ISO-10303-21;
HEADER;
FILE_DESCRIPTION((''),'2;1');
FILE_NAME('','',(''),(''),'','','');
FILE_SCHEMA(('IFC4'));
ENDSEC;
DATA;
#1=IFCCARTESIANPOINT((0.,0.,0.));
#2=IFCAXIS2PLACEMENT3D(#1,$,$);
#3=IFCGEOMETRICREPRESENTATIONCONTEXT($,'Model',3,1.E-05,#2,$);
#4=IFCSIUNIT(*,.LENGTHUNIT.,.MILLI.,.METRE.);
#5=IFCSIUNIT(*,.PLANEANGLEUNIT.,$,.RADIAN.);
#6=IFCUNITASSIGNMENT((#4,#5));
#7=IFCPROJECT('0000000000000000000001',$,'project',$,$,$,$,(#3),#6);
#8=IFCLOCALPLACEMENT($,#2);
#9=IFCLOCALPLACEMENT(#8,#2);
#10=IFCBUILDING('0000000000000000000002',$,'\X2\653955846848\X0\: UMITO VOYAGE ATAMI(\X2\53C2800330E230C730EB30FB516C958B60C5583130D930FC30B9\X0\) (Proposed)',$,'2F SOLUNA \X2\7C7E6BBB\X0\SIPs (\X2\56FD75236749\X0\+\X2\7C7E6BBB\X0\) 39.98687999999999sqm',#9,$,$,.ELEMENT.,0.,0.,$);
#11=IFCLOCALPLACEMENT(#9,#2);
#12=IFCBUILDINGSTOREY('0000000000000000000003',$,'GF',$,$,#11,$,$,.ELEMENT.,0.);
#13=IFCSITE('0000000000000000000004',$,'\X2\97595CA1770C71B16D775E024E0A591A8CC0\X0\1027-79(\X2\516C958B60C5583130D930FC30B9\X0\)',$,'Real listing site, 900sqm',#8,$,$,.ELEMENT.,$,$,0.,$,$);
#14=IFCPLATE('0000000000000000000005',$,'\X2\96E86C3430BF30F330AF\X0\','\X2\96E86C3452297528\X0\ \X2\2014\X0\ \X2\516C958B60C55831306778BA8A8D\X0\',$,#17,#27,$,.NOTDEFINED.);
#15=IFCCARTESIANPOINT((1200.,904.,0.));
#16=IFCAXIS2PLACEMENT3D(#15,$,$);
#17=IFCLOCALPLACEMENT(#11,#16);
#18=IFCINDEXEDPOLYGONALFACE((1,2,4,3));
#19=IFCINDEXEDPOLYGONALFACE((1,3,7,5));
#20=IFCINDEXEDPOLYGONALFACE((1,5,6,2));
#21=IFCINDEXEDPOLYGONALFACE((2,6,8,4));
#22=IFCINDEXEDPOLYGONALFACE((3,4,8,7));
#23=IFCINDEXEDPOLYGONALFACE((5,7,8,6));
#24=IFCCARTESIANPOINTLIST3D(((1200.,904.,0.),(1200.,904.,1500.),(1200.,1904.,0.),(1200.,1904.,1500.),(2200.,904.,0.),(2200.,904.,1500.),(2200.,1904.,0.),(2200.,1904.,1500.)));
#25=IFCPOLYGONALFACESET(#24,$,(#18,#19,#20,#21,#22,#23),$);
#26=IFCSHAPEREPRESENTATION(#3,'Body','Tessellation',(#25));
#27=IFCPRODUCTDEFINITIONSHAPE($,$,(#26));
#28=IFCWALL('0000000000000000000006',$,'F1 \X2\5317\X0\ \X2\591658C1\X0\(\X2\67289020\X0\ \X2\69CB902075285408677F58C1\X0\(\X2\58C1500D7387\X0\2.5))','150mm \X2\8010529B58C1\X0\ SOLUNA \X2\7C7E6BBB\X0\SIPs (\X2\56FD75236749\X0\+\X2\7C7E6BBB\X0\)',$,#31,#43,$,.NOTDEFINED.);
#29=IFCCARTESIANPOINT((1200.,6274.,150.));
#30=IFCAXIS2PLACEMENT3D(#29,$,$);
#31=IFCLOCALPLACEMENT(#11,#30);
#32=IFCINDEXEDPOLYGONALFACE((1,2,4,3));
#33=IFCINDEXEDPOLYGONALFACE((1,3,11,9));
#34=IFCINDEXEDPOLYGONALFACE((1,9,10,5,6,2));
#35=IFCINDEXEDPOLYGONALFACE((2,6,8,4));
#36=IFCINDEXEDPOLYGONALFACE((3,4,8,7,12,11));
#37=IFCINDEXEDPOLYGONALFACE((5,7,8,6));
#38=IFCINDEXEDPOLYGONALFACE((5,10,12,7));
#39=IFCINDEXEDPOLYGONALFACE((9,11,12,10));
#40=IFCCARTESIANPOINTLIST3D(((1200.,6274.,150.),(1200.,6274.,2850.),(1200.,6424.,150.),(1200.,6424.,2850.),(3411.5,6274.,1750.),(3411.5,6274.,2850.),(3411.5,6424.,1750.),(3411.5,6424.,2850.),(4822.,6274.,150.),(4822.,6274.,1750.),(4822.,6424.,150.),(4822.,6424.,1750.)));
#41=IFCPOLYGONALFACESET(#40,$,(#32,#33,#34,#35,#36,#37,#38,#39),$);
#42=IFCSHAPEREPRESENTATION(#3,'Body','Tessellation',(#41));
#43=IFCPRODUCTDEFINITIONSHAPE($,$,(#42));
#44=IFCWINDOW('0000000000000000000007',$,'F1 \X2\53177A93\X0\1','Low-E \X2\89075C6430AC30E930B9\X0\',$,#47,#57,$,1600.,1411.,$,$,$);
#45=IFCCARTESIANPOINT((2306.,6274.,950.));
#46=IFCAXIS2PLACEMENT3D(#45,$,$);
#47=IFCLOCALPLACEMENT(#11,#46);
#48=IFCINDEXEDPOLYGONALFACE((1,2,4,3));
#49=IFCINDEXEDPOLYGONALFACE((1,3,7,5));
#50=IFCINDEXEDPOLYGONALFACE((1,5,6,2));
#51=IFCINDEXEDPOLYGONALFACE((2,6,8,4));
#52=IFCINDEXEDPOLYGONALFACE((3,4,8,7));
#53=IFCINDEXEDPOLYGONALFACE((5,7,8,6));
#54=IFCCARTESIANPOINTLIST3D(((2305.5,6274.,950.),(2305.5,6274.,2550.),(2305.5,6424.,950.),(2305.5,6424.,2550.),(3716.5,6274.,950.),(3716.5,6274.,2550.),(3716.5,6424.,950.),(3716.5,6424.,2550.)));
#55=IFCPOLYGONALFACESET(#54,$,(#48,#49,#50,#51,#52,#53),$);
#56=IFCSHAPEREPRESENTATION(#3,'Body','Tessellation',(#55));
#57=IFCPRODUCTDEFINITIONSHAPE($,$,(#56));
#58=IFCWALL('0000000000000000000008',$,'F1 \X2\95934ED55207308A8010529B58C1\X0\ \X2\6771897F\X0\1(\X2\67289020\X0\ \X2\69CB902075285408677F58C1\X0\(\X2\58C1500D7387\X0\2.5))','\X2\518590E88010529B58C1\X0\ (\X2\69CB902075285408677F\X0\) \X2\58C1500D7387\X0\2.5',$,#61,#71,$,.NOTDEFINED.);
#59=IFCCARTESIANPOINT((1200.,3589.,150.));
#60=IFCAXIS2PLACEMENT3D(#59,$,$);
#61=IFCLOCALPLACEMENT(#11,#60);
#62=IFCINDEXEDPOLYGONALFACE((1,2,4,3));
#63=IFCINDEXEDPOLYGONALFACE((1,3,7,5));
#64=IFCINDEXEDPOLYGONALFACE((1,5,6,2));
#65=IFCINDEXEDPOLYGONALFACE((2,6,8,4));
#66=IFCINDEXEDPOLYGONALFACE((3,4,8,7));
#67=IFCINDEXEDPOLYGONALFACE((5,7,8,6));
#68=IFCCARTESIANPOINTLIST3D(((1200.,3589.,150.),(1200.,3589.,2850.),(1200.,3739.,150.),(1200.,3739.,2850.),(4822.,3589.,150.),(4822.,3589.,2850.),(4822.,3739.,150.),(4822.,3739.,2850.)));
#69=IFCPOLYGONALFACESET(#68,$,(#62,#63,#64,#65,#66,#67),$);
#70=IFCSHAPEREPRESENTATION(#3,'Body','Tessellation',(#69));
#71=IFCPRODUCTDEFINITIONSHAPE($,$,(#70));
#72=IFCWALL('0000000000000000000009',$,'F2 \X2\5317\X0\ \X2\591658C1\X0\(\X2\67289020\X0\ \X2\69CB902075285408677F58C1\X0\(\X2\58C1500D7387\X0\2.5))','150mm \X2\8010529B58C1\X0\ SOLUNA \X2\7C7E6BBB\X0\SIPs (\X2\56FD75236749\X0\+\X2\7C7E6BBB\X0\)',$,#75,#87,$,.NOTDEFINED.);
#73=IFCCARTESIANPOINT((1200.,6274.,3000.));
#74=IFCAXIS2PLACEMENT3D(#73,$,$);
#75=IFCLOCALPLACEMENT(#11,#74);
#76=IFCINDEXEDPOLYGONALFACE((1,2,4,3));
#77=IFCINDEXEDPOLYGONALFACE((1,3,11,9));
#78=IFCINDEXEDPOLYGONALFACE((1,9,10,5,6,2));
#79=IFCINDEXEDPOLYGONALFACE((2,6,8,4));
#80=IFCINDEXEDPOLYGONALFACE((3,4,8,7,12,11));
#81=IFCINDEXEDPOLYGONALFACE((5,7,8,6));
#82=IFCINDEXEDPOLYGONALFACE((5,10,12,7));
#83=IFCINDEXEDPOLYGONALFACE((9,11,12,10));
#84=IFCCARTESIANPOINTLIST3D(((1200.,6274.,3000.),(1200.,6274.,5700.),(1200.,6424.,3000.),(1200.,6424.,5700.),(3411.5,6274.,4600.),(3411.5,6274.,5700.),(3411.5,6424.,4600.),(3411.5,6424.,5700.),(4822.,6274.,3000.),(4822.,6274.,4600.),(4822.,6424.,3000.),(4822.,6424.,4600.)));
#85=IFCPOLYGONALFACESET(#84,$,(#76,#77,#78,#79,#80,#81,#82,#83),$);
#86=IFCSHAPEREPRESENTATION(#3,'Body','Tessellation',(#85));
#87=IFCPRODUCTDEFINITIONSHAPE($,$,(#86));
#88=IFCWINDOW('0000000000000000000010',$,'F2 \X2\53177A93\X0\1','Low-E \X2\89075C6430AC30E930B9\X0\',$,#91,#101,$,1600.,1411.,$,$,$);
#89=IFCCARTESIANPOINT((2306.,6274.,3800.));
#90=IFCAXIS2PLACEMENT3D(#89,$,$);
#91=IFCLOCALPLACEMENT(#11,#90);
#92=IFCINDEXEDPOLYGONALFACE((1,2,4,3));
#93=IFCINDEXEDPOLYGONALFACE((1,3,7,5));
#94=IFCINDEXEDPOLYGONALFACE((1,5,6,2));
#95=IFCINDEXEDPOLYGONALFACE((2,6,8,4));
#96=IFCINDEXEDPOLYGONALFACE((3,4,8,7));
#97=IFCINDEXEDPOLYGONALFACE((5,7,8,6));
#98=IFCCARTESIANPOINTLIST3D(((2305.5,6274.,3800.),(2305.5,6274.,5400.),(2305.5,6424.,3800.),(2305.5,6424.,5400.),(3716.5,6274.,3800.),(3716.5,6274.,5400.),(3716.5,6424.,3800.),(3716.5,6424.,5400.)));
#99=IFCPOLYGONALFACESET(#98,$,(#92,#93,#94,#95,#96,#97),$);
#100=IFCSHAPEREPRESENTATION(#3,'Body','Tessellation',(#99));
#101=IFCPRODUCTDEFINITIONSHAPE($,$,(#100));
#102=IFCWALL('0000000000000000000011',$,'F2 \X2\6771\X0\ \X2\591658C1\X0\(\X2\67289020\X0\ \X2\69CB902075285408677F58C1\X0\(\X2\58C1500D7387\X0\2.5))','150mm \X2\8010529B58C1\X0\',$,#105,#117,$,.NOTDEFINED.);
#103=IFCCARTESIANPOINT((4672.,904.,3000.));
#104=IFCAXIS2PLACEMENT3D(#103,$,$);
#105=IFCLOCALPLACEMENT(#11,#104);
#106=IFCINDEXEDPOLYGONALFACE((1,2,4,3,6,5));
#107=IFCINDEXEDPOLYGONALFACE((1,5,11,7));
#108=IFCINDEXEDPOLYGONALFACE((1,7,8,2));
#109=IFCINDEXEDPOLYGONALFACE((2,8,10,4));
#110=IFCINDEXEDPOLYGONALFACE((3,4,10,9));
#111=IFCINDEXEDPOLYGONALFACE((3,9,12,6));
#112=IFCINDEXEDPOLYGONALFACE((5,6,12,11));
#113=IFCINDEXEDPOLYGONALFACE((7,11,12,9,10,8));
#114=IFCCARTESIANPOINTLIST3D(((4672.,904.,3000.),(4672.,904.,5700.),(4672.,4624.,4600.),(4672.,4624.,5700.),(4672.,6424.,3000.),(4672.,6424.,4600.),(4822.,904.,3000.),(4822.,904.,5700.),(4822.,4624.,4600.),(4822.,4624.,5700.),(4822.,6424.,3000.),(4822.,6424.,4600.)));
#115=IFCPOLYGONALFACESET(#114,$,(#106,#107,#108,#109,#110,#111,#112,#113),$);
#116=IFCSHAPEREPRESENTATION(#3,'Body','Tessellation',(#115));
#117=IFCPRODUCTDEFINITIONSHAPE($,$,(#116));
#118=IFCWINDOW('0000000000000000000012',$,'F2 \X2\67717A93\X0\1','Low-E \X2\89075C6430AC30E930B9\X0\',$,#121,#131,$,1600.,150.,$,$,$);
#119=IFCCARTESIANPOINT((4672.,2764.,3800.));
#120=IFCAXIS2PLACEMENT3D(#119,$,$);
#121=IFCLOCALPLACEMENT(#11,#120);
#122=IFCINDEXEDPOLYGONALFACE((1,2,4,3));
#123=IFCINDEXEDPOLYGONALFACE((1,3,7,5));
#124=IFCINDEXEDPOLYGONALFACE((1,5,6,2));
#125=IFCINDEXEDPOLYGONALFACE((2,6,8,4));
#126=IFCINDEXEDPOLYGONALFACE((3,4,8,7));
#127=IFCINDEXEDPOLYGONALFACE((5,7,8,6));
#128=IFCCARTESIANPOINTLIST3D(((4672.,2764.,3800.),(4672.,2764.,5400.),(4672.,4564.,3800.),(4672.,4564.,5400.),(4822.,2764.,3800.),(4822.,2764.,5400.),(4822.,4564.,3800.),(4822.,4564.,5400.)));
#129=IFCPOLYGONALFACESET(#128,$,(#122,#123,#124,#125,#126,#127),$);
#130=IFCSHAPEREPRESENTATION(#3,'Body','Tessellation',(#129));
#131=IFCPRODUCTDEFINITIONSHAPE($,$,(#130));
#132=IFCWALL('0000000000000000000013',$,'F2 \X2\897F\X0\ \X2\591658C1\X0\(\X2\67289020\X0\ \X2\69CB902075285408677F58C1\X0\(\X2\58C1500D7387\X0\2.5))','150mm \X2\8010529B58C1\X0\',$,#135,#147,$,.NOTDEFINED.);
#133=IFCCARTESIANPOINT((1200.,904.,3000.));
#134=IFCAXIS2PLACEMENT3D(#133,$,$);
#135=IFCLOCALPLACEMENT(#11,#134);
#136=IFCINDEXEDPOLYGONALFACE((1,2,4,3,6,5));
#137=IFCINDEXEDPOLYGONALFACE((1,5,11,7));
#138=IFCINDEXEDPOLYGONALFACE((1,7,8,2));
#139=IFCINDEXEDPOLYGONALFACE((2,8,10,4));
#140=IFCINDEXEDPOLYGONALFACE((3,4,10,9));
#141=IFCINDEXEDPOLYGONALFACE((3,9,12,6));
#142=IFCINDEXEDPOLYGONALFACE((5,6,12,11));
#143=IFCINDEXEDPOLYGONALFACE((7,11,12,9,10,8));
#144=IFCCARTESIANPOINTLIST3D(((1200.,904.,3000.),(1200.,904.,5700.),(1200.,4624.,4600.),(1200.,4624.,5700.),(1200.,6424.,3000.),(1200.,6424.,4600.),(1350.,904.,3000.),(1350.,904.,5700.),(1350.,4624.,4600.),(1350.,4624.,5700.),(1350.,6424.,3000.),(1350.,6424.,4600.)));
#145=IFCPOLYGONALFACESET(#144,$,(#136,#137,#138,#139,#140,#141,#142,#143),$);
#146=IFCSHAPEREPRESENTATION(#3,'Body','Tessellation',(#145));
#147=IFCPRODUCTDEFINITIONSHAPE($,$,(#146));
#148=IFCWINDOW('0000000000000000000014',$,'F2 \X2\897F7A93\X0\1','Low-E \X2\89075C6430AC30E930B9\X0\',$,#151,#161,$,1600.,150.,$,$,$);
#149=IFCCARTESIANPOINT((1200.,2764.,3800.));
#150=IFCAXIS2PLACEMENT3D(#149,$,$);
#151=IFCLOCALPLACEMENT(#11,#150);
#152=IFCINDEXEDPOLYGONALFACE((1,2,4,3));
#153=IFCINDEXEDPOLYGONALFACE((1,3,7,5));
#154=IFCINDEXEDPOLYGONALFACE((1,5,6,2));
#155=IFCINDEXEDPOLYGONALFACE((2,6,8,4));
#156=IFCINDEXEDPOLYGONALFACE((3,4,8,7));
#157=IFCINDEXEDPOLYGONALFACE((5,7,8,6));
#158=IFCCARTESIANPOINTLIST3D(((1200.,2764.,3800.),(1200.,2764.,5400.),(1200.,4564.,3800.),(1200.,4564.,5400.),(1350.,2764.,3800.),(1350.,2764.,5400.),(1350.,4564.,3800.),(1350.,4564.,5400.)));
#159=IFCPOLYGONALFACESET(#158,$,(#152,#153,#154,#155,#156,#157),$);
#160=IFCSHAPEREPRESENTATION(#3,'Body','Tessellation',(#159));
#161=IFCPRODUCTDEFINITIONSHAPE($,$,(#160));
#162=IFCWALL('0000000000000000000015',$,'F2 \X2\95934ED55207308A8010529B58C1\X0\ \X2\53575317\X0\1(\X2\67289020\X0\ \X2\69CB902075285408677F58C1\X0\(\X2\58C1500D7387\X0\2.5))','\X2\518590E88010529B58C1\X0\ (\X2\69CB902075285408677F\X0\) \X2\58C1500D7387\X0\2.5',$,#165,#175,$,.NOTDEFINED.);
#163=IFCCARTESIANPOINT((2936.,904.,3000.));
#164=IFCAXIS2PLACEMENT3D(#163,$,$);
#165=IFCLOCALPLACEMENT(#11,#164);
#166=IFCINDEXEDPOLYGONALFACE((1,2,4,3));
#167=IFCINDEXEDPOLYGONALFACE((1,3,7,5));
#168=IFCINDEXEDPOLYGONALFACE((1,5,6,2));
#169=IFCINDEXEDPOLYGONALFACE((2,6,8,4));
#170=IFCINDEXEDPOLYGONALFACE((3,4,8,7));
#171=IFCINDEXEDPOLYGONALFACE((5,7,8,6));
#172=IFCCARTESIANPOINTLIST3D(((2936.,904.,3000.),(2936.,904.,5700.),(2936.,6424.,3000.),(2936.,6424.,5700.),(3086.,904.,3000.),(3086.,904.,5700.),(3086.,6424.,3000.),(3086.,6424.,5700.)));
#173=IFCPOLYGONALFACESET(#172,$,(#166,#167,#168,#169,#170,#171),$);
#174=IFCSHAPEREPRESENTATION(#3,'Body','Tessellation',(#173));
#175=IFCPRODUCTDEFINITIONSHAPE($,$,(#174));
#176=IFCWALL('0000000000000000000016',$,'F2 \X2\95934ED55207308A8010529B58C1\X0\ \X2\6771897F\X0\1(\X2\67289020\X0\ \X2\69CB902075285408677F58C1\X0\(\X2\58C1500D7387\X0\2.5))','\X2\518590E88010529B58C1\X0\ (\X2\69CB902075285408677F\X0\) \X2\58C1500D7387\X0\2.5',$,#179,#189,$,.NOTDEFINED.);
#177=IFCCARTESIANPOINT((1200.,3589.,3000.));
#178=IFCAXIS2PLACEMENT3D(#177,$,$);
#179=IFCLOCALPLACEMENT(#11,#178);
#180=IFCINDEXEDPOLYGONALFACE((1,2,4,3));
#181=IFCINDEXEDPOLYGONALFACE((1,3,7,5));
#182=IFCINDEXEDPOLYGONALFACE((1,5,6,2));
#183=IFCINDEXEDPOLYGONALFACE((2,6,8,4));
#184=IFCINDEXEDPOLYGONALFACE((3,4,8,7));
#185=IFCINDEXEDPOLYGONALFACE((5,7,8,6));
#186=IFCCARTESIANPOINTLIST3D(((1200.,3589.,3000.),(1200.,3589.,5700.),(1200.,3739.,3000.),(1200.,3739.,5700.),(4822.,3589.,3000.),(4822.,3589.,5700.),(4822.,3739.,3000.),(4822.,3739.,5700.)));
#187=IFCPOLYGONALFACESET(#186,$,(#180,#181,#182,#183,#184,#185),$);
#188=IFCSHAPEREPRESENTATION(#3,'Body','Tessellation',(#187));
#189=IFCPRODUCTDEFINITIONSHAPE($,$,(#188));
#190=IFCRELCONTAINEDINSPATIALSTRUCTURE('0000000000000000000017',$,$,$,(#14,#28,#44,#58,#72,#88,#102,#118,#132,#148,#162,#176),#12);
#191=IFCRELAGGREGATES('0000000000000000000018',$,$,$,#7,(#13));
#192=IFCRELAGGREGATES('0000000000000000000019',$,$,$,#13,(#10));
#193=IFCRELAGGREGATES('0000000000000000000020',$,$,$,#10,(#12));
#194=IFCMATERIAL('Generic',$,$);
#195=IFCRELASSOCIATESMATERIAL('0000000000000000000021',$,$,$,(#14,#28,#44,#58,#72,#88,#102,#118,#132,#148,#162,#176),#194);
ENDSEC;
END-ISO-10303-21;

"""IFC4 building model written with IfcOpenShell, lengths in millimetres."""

from ifc_helpers import new_model, si_unit, frame, frame_2d, origin, place, context, project, spatial, rectangle, extrude, material, element, fill, save


model = new_model("IFC4")

# Units and contexts
model_context = context("Model", 3, precision=1e-05, world=origin())
ifc_project = project(units=[si_unit("LENGTHUNIT", "METRE", prefix="MILLI"), si_unit("PLANEANGLEUNIT", "RADIAN")], contexts=[model_context])

# Site, building, storey
site_placement = place(None, origin())
site = spatial("IfcSite", under=ifc_project, at=site_placement, Name="静岡県熱海市上多賀1027-79(公開情報ベース)", ObjectType="Real listing site, 900sqm", CompositionType="ELEMENT", RefElevation=0.0)
building_placement = place(site_placement, origin())
building = spatial("IfcBuilding", under=site, at=building_placement, Name="改善案: UMITO VOYAGE ATAMI(参考モデル・公開情報ベース) (Proposed)", ObjectType="2F SOLUNA 籾殻SIPs (国産杉+籾殻) 39.98687999999999sqm", CompositionType="ELEMENT", ElevationOfRefHeight=0.0, ElevationOfTerrain=0.0)
storey_placement = place(building_placement, origin())
storey = spatial("IfcBuildingStorey", under=building, at=storey_placement, Name="GF", CompositionType="ELEMENT", Elevation=0.0)

# Plate
ifc_material_1 = material(Name="Generic")
plate_placement = place(storey_placement, frame((1200.0, 904.0, 0.0)))
element("IfcPlate", 1, at=plate_placement, inside=storey, material=ifc_material_1, Name="雨水タンク", Description="雨水利用 — 公開情報で確認", PredefinedType="NOTDEFINED", context=model_context, shape_type="SweptSolid", body=[
    extrude(rectangle(XDim=1000.0, YDim=1000.0, at=frame_2d((500.0, 500.0))), frame((1200.0, 904.0, 0.0)), (0.0, 0.0, 1.0), 1500.0),
])

# Wall, opening, window
wall_1_placement = place(storey_placement, frame((1200.0, 6274.0, 150.0)))
wall_1 = element("IfcWall", 2, at=wall_1_placement, inside=storey, material=ifc_material_1, Name="F1 北 外壁(木造 構造用合板壁(壁倍率2.5))", Description="150mm 耐力壁 SOLUNA 籾殻SIPs (国産杉+籾殻)", PredefinedType="NOTDEFINED", context=model_context, shape_type="SweptSolid", body=[
    extrude(rectangle(XDim=3622.0, YDim=150.0, at=frame_2d((1811.0, 75.0))), frame((1200.0, 6274.0, 150.0)), (0.0, 0.0, 1.0), 2700.0),
])
opening_1_placement = place(storey_placement, frame((2306.0, 6274.0, 950.0)))
opening_1 = element("IfcOpeningElement", 3, at=opening_1_placement, cuts=wall_1, PredefinedType="NOTDEFINED", context=model_context, shape_type="SweptSolid", body=[
    extrude(rectangle(XDim=1411.0, YDim=150.0, at=frame_2d((705.0, 75.0))), frame((2306.0, 6274.0, 950.0)), (0.0, 0.0, 1.0), 1600.0),
])
window_1_placement = place(storey_placement, frame((2306.0, 6274.0, 950.0)))
window_1 = element("IfcWindow", 4, at=window_1_placement, inside=storey, material=ifc_material_1, Name="F1 北窓1", Description="Low-E 複層ガラス", OverallHeight=1600.0, OverallWidth=1411.0, context=model_context, shape_type="SweptSolid", body=[
    extrude(rectangle(XDim=1411.0, YDim=150.0, at=frame_2d((705.0, 75.0))), frame((2306.0, 6274.0, 950.0)), (0.0, 0.0, 1.0), 1600.0),
])
fill(opening_1, window_1)

# Wall
wall_2_placement = place(storey_placement, frame((1200.0, 3589.0, 150.0)))
element("IfcWall", 5, at=wall_2_placement, inside=storey, material=ifc_material_1, Name="F1 間仕切り耐力壁 東西1(木造 構造用合板壁(壁倍率2.5))", Description="内部耐力壁 (構造用合板) 壁倍率2.5", PredefinedType="NOTDEFINED", context=model_context, shape_type="SweptSolid", body=[
    extrude(rectangle(XDim=3622.0, YDim=150.0, at=frame_2d((1811.0, 75.0))), frame((1200.0, 3589.0, 150.0)), (0.0, 0.0, 1.0), 2700.0),
])

# Walls, openings, windows
wall_3_placement = place(storey_placement, frame((1200.0, 6274.0, 3000.0)))
wall_3 = element("IfcWall", 6, at=wall_3_placement, inside=storey, material=ifc_material_1, Name="F2 北 外壁(木造 構造用合板壁(壁倍率2.5))", Description="150mm 耐力壁 SOLUNA 籾殻SIPs (国産杉+籾殻)", PredefinedType="NOTDEFINED", context=model_context, shape_type="SweptSolid", body=[
    extrude(rectangle(XDim=3622.0, YDim=150.0, at=frame_2d((1811.0, 75.0))), frame((1200.0, 6274.0, 3000.0)), (0.0, 0.0, 1.0), 2700.0),
])
opening_2_placement = place(storey_placement, frame((2306.0, 6274.0, 3800.0)))
opening_2 = element("IfcOpeningElement", 7, at=opening_2_placement, cuts=wall_3, PredefinedType="NOTDEFINED", context=model_context, shape_type="SweptSolid", body=[
    extrude(rectangle(XDim=1411.0, YDim=150.0, at=frame_2d((705.0, 75.0))), frame((2306.0, 6274.0, 3800.0)), (0.0, 0.0, 1.0), 1600.0),
])
window_2_placement = place(storey_placement, frame((2306.0, 6274.0, 3800.0)))
window_2 = element("IfcWindow", 8, at=window_2_placement, inside=storey, material=ifc_material_1, Name="F2 北窓1", Description="Low-E 複層ガラス", OverallHeight=1600.0, OverallWidth=1411.0, context=model_context, shape_type="SweptSolid", body=[
    extrude(rectangle(XDim=1411.0, YDim=150.0, at=frame_2d((705.0, 75.0))), frame((2306.0, 6274.0, 3800.0)), (0.0, 0.0, 1.0), 1600.0),
])
fill(opening_2, window_2)
wall_4_placement = place(storey_placement, frame((4672.0, 904.0, 3000.0)))
wall_4 = element("IfcWall", 9, at=wall_4_placement, inside=storey, material=ifc_material_1, Name="F2 東 外壁(木造 構造用合板壁(壁倍率2.5))", Description="150mm 耐力壁", PredefinedType="NOTDEFINED", context=model_context, shape_type="SweptSolid", body=[
    extrude(rectangle(XDim=150.0, YDim=5520.0, at=frame_2d((75.0, 2760.0))), frame((4672.0, 904.0, 3000.0)), (0.0, 0.0, 1.0), 2700.0),
])
opening_3_placement = place(storey_placement, frame((4672.0, 2764.0, 3800.0)))
opening_3 = element("IfcOpeningElement", 10, at=opening_3_placement, cuts=wall_4, PredefinedType="NOTDEFINED", context=model_context, shape_type="SweptSolid", body=[
    extrude(rectangle(XDim=150.0, YDim=1800.0, at=frame_2d((75.0, 900.0))), frame((4672.0, 2764.0, 3800.0)), (0.0, 0.0, 1.0), 1600.0),
])
window_3_placement = place(storey_placement, frame((4672.0, 2764.0, 3800.0)))
window_3 = element("IfcWindow", 11, at=window_3_placement, inside=storey, material=ifc_material_1, Name="F2 東窓1", Description="Low-E 複層ガラス", OverallHeight=1600.0, OverallWidth=150.0, context=model_context, shape_type="SweptSolid", body=[
    extrude(rectangle(XDim=150.0, YDim=1800.0, at=frame_2d((75.0, 900.0))), frame((4672.0, 2764.0, 3800.0)), (0.0, 0.0, 1.0), 1600.0),
])
fill(opening_3, window_3)
wall_5_placement = place(storey_placement, frame((1200.0, 904.0, 3000.0)))
wall_5 = element("IfcWall", 12, at=wall_5_placement, inside=storey, material=ifc_material_1, Name="F2 西 外壁(木造 構造用合板壁(壁倍率2.5))", Description="150mm 耐力壁", PredefinedType="NOTDEFINED", context=model_context, shape_type="SweptSolid", body=[
    extrude(rectangle(XDim=150.0, YDim=5520.0, at=frame_2d((75.0, 2760.0))), frame((1200.0, 904.0, 3000.0)), (0.0, 0.0, 1.0), 2700.0),
])
opening_4_placement = place(storey_placement, frame((1200.0, 2764.0, 3800.0)))
opening_4 = element("IfcOpeningElement", 13, at=opening_4_placement, cuts=wall_5, PredefinedType="NOTDEFINED", context=model_context, shape_type="SweptSolid", body=[
    extrude(rectangle(XDim=150.0, YDim=1800.0, at=frame_2d((75.0, 900.0))), frame((1200.0, 2764.0, 3800.0)), (0.0, 0.0, 1.0), 1600.0),
])
window_4_placement = place(storey_placement, frame((1200.0, 2764.0, 3800.0)))
window_4 = element("IfcWindow", 14, at=window_4_placement, inside=storey, material=ifc_material_1, Name="F2 西窓1", Description="Low-E 複層ガラス", OverallHeight=1600.0, OverallWidth=150.0, context=model_context, shape_type="SweptSolid", body=[
    extrude(rectangle(XDim=150.0, YDim=1800.0, at=frame_2d((75.0, 900.0))), frame((1200.0, 2764.0, 3800.0)), (0.0, 0.0, 1.0), 1600.0),
])
fill(opening_4, window_4)

# Walls
wall_6_placement = place(storey_placement, frame((2936.0, 904.0, 3000.0)))
element("IfcWall", 15, at=wall_6_placement, inside=storey, material=ifc_material_1, Name="F2 間仕切り耐力壁 南北1(木造 構造用合板壁(壁倍率2.5))", Description="内部耐力壁 (構造用合板) 壁倍率2.5", PredefinedType="NOTDEFINED", context=model_context, shape_type="SweptSolid", body=[
    extrude(rectangle(XDim=150.0, YDim=5520.0, at=frame_2d((75.0, 2760.0))), frame((2936.0, 904.0, 3000.0)), (0.0, 0.0, 1.0), 2700.0),
])
wall_7_placement = place(storey_placement, frame((1200.0, 3589.0, 3000.0)))
element("IfcWall", 16, at=wall_7_placement, inside=storey, material=ifc_material_1, Name="F2 間仕切り耐力壁 東西1(木造 構造用合板壁(壁倍率2.5))", Description="内部耐力壁 (構造用合板) 壁倍率2.5", PredefinedType="NOTDEFINED", context=model_context, shape_type="SweptSolid", body=[
    extrude(rectangle(XDim=3622.0, YDim=150.0, at=frame_2d((1811.0, 75.0))), frame((1200.0, 3589.0, 3000.0)), (0.0, 0.0, 1.0), 2700.0),
])

save(model, "model.ifc")
